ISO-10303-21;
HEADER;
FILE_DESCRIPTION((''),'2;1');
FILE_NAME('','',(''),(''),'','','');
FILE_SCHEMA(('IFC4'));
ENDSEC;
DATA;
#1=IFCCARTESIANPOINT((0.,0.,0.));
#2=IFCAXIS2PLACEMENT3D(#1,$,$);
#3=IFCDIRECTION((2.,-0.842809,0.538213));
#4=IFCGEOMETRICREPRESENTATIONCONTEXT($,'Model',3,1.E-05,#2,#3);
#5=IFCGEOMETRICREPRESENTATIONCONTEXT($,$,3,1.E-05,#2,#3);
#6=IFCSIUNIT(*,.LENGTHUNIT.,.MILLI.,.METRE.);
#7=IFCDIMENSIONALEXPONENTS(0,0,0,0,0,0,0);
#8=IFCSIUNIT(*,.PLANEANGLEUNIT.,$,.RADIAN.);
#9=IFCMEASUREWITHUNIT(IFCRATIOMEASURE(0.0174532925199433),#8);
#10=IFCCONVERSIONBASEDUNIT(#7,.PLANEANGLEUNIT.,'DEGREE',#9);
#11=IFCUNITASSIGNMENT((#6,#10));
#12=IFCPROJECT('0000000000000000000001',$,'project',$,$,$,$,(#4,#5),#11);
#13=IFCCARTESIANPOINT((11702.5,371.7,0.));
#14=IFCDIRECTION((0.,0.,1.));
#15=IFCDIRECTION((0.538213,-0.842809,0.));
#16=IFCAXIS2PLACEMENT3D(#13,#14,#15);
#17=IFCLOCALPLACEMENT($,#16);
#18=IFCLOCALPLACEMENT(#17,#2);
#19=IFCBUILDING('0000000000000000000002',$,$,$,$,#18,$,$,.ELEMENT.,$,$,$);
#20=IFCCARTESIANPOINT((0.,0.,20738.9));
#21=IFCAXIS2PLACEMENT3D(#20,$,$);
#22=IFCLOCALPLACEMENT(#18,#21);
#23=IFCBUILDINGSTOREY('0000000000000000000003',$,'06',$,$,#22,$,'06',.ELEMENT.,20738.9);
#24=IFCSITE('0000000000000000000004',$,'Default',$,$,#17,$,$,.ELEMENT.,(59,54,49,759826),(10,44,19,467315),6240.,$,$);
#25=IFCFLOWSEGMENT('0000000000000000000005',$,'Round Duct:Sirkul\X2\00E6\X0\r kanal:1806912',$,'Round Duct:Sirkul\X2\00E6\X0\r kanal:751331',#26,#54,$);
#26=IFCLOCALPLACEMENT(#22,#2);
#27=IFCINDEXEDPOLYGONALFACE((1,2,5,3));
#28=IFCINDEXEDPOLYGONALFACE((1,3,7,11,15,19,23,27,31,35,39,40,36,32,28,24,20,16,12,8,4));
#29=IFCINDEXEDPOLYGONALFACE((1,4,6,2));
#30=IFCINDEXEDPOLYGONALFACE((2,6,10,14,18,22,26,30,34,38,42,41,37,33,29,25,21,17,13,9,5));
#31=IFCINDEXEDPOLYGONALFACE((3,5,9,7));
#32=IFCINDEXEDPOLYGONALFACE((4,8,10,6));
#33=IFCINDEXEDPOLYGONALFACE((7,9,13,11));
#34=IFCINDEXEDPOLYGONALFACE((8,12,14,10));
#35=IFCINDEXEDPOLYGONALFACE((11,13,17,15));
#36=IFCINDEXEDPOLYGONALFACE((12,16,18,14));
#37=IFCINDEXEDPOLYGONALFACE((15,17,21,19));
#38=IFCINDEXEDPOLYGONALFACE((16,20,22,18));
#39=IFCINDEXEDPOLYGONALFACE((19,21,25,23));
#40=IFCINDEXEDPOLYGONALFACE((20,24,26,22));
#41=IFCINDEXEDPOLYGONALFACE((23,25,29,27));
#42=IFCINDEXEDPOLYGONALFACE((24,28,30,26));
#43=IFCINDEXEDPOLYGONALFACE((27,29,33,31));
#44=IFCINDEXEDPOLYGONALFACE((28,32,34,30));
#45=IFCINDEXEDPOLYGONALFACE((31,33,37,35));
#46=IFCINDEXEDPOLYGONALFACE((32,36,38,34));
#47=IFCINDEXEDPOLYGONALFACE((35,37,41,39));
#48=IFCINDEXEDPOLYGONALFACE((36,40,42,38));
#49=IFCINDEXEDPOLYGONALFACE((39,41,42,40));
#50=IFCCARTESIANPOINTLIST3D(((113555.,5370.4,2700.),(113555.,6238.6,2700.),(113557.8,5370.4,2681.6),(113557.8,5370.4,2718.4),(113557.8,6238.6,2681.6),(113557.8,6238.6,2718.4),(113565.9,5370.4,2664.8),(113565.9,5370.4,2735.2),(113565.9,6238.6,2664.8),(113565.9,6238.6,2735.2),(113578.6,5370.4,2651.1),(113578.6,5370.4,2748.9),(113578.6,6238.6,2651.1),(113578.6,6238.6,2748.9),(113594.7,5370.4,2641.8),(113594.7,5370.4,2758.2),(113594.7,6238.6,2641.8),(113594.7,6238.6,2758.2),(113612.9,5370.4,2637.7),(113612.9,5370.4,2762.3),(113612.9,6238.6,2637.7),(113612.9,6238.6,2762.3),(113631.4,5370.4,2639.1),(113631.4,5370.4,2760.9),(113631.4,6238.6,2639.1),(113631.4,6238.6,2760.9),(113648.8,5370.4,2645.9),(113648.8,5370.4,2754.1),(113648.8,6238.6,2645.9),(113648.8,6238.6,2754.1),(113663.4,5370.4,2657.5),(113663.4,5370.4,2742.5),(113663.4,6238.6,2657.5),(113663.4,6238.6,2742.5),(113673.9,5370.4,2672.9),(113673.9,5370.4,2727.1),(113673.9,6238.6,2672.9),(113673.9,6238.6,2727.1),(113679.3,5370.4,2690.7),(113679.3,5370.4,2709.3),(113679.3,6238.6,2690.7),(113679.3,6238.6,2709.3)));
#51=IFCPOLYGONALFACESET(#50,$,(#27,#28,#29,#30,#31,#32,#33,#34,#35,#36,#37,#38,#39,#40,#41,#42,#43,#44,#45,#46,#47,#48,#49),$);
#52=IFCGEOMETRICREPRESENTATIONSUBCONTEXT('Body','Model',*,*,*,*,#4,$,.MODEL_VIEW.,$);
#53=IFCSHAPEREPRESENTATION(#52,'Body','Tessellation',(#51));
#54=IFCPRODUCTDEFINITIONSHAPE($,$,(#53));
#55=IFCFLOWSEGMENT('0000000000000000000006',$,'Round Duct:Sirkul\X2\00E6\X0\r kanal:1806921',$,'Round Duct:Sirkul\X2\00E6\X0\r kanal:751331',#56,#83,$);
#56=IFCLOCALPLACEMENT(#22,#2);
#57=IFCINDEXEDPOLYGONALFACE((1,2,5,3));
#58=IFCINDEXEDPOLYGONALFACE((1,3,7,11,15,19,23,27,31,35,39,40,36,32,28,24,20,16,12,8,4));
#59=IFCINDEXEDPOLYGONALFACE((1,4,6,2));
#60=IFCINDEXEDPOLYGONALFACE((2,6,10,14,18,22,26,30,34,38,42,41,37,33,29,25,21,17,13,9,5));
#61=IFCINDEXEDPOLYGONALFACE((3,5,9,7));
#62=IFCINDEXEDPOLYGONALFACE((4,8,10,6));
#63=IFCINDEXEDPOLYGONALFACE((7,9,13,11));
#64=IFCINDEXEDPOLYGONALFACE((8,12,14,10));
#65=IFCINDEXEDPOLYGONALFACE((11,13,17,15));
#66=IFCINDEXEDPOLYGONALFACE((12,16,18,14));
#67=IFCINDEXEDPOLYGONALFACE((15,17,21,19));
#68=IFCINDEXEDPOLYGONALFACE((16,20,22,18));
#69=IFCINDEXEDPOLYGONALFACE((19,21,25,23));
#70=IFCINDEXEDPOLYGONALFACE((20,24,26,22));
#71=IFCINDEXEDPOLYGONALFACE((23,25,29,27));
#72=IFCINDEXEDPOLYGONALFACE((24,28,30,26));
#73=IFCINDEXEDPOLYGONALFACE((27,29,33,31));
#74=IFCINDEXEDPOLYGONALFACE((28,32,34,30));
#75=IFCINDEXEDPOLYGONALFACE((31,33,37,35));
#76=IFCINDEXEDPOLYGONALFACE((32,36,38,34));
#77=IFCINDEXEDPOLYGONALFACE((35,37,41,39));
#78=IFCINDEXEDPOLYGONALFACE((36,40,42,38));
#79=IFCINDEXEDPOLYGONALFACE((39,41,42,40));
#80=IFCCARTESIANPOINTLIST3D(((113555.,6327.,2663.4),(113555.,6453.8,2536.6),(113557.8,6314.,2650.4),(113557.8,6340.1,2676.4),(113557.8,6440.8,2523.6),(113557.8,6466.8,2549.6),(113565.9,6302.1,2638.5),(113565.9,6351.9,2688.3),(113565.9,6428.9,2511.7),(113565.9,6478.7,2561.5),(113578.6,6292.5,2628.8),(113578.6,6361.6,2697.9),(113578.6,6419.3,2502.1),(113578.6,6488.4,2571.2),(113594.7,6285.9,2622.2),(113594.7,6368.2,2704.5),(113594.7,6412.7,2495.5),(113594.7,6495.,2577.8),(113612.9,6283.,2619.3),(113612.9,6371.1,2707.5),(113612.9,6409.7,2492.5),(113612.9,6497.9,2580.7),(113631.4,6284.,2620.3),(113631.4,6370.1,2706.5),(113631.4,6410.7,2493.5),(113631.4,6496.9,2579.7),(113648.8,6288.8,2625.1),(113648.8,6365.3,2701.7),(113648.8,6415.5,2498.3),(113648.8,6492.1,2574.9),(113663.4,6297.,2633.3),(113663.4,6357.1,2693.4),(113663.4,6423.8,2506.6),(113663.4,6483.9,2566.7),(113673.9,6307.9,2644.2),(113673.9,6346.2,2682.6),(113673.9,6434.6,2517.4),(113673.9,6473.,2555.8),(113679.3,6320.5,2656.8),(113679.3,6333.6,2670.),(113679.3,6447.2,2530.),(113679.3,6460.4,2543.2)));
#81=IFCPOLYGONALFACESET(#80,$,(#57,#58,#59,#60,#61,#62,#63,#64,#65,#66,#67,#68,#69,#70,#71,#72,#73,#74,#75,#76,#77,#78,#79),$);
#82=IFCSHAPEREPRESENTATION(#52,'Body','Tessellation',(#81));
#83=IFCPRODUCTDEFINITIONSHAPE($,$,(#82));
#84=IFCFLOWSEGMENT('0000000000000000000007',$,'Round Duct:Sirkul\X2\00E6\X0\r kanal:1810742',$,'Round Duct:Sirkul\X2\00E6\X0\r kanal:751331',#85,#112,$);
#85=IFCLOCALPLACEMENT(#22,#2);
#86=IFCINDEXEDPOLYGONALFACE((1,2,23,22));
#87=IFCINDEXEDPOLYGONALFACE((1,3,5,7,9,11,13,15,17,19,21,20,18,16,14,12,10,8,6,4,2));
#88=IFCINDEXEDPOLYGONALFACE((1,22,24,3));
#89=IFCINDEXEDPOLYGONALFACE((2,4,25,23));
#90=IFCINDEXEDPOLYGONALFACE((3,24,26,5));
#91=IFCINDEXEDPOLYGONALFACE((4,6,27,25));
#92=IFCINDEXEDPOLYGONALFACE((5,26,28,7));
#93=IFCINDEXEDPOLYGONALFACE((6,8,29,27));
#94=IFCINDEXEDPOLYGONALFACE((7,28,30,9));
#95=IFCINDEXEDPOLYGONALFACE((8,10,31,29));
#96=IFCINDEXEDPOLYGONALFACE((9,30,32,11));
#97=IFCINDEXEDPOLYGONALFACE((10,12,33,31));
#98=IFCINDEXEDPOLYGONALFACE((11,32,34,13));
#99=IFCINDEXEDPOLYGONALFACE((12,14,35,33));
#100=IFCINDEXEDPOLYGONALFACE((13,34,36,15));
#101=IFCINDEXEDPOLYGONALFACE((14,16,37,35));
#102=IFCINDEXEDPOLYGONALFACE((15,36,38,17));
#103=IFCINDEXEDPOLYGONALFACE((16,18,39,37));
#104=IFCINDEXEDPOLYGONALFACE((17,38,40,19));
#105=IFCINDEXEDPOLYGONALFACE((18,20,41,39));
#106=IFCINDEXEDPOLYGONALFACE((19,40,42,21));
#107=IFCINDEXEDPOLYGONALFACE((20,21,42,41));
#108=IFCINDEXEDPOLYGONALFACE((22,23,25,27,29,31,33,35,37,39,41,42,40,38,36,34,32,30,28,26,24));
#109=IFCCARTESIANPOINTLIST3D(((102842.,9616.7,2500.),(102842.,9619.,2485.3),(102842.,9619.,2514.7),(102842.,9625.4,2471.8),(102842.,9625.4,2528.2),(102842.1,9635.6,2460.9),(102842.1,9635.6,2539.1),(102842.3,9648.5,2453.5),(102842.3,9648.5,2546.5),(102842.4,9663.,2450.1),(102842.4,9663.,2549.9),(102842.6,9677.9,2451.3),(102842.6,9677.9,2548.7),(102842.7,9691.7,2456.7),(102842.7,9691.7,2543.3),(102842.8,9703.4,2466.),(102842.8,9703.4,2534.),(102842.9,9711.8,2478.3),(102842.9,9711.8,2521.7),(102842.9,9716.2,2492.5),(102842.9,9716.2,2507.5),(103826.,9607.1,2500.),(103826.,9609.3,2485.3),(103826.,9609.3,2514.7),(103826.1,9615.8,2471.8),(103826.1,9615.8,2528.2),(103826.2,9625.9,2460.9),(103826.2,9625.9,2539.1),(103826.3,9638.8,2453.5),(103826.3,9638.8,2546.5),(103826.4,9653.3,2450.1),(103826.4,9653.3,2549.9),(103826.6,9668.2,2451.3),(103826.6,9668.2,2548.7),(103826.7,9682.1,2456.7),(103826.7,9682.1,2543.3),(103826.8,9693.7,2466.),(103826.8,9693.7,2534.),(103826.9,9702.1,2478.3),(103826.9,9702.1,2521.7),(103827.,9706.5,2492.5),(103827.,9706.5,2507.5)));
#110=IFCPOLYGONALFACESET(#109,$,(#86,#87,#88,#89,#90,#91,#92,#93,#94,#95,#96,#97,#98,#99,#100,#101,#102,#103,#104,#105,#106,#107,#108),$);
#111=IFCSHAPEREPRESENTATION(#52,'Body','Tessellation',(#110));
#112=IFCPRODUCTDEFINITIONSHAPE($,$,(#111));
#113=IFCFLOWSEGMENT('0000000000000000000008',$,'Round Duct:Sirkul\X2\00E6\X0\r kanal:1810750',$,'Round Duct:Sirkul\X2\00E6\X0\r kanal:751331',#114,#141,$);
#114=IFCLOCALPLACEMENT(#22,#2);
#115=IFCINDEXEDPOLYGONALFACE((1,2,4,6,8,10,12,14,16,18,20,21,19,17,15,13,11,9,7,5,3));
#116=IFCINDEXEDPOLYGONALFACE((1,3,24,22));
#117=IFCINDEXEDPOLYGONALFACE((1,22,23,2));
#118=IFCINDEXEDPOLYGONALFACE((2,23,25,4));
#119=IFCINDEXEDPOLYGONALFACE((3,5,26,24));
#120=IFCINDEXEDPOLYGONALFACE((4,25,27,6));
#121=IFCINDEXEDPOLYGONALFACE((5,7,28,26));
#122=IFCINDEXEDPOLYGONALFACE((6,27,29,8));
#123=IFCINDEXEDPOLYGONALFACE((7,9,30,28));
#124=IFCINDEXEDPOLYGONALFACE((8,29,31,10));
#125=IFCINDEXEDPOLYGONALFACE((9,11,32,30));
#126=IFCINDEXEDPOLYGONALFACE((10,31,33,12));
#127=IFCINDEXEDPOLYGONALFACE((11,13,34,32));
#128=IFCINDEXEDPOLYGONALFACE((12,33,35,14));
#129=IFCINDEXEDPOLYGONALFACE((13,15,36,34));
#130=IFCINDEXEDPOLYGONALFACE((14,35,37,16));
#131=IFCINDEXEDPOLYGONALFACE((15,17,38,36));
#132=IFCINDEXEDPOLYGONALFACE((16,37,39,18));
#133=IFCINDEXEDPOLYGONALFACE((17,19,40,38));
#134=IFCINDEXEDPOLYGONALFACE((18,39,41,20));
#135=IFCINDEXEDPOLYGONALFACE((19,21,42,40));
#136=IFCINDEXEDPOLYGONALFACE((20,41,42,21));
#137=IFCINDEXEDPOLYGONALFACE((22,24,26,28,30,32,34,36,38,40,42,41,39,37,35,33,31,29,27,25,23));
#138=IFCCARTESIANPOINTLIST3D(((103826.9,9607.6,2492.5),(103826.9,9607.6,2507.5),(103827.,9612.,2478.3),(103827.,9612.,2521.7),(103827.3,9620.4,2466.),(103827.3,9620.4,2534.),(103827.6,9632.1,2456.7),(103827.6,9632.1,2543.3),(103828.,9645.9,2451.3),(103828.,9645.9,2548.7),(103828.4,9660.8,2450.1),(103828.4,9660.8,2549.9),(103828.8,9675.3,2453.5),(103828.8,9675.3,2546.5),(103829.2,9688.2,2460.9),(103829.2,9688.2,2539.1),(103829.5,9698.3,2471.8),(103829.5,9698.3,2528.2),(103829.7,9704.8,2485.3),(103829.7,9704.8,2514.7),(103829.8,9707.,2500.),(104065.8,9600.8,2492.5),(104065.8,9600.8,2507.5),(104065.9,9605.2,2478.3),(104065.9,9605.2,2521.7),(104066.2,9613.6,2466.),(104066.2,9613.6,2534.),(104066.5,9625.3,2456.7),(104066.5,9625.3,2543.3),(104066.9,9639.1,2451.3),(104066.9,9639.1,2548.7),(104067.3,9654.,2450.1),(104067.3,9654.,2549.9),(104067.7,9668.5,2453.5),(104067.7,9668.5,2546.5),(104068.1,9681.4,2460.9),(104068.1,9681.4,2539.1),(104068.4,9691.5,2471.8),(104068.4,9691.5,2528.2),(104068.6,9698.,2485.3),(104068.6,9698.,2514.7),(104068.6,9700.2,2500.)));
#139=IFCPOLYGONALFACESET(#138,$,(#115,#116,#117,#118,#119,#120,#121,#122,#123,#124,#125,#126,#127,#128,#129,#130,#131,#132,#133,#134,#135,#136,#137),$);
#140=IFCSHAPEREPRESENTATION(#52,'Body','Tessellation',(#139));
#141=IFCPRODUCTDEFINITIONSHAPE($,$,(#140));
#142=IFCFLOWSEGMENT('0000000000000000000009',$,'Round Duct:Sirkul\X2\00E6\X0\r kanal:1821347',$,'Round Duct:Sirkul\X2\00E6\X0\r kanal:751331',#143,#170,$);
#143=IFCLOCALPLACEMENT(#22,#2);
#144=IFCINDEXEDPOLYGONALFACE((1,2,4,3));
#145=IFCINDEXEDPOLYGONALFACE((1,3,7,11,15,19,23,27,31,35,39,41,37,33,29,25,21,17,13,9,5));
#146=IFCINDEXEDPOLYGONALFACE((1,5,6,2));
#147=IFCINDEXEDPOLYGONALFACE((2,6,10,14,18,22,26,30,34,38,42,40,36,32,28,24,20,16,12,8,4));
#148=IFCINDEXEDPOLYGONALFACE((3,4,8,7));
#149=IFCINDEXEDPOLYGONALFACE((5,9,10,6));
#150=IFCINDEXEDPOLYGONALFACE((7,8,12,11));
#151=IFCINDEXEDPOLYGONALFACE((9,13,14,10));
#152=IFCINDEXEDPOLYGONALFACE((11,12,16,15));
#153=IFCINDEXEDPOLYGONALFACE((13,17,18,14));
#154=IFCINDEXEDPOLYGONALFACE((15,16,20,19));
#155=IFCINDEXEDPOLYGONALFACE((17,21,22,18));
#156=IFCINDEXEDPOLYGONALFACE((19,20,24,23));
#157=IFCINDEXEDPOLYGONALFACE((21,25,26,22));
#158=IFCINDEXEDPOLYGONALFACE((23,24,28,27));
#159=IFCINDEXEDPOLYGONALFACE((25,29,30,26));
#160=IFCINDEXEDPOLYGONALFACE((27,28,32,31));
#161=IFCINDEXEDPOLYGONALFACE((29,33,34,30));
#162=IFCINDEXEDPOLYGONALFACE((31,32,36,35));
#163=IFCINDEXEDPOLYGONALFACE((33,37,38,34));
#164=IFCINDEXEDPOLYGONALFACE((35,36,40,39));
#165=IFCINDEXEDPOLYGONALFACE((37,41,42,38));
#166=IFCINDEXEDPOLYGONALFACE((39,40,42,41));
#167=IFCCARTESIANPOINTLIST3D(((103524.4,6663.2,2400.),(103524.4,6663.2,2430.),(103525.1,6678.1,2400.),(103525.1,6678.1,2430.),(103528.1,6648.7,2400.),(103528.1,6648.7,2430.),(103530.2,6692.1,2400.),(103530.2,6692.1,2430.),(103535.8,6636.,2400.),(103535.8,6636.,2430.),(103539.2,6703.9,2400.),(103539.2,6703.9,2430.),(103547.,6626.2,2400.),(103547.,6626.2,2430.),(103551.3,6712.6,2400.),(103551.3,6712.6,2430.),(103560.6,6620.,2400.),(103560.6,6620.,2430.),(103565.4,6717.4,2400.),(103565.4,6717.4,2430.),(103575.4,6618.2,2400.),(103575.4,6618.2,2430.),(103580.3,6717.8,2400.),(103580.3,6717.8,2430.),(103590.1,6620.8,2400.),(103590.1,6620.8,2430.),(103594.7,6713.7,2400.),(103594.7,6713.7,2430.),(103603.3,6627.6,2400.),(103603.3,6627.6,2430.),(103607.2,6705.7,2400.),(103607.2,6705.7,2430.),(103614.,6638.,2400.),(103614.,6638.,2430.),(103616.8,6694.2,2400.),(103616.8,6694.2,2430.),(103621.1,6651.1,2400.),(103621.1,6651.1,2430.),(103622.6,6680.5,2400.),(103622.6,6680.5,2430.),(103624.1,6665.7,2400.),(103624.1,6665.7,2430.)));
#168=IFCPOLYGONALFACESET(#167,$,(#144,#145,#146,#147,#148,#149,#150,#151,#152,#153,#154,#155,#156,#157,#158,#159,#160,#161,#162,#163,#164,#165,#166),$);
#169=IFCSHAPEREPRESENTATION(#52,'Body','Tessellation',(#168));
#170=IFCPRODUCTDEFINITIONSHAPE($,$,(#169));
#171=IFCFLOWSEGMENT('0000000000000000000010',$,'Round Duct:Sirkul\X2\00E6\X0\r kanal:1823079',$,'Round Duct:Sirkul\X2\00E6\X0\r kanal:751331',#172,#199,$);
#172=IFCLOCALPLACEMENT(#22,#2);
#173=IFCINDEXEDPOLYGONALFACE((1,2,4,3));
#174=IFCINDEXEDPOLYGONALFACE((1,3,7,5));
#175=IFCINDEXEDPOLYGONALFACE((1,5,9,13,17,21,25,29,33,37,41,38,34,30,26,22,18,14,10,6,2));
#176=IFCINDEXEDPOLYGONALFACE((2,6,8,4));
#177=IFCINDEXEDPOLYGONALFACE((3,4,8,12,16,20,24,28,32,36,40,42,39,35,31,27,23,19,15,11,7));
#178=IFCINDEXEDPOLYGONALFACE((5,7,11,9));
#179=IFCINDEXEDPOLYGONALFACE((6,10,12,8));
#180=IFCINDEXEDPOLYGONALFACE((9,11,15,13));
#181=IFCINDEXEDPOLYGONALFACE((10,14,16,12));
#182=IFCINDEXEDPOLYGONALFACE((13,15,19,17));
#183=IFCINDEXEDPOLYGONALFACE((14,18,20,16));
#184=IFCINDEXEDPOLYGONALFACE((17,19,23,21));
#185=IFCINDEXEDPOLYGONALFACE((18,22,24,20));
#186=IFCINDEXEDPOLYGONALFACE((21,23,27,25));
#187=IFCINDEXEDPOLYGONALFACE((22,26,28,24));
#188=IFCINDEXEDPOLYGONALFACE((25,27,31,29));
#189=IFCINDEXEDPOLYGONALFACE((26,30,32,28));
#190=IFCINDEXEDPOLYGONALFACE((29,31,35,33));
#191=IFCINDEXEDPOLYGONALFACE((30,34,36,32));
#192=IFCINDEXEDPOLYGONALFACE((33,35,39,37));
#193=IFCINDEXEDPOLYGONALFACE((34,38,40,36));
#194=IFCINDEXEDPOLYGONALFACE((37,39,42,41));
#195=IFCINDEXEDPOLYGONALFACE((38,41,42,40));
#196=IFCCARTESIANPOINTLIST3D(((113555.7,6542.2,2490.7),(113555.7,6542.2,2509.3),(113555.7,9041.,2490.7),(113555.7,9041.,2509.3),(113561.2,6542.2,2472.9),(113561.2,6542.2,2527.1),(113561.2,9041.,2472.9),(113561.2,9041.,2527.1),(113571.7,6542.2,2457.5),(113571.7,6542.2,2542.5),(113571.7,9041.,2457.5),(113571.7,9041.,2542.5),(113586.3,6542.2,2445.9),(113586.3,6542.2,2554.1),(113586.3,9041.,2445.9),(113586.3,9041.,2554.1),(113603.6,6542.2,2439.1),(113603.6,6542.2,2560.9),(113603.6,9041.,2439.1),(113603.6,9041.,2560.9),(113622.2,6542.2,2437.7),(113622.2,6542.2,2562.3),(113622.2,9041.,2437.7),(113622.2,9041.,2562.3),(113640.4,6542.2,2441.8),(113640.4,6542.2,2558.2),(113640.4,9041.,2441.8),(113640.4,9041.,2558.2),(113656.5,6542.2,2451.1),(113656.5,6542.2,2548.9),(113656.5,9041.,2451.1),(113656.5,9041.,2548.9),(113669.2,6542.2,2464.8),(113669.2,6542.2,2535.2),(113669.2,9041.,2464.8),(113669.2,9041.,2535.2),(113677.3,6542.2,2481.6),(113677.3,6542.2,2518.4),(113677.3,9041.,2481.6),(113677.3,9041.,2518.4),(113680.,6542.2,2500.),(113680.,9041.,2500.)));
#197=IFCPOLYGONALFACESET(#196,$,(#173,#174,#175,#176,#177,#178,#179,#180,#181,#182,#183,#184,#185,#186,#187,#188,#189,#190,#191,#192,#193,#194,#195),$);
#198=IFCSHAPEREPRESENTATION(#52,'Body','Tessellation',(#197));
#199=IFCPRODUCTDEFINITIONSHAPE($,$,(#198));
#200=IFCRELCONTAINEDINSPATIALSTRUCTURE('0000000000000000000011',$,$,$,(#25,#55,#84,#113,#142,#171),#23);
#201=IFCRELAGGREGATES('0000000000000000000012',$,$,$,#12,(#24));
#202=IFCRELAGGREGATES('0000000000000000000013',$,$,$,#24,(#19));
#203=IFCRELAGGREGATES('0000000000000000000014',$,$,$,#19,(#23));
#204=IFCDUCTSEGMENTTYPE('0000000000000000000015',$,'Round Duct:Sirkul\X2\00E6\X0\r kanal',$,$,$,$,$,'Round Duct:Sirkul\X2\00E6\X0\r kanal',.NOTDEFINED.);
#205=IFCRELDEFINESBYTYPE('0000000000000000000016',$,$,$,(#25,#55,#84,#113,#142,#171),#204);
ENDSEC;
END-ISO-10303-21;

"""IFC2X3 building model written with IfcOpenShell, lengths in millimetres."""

from ifc_helpers import new_model, entity, si_unit, converted_unit, direction, frame, frame_2d, origin, origin_2d_with_axis, place, context, subcontext, project, spatial, circle, extrude, type_object, element, save


model = new_model("IFC2X3")

# Units and contexts
model_context = context("Model", 3, precision=1e-05, world=origin(), true_north=direction((2.0, -0.842809, 0.538213)))
context_of_model = context(None, 3, precision=1e-05, world=origin(), true_north=direction((2.0, -0.842809, 0.538213)))
body_context = subcontext(model_context, "Body", "Model", "MODEL_VIEW")
ifc_project = project(units=[si_unit("LENGTHUNIT", "METRE", prefix="MILLI"), converted_unit("PLANEANGLEUNIT", "DEGREE", entity("IfcRatioMeasure", 0.0174532925199433), si_unit("PLANEANGLEUNIT", "RADIAN"), dimensions=[0, 0, 0, 0, 0, 0, 0])], contexts=[model_context, context_of_model])

# Site, building, storey
site_placement = place(None, frame((11702.5, 371.7, 0.0), z_axis=(0.0, 0.0, 1.0), x_axis=(0.538213, -0.842809, 0.0)))
site = spatial("IfcSite", under=ifc_project, at=site_placement, Name="Default", CompositionType="ELEMENT", RefLatitude=(59, 54, 49, 759826), RefLongitude=(10, 44, 19, 467315), RefElevation=6240.0)
building_placement = place(site_placement, origin())
building = spatial("IfcBuilding", under=site, at=building_placement, CompositionType="ELEMENT")
storey_placement = place(building_placement, frame((0.0, 0.0, 20738.9)))
storey = spatial("IfcBuildingStorey", under=building, at=storey_placement, Name="06", LongName="06", CompositionType="ELEMENT", Elevation=20738.9)

# Flow segments
duct_segment_type = type_object("IfcDuctSegmentType", Name="Round Duct:Sirkulær kanal", ElementType="Round Duct:Sirkulær kanal", PredefinedType="NOTDEFINED")
flow_segment_1_placement = place(storey_placement, origin())
element("IfcFlowSegment", 1, at=flow_segment_1_placement, inside=storey, type_object=duct_segment_type, Name="Round Duct:Sirkulær kanal:1806912", ObjectType="Round Duct:Sirkulær kanal:751331", context=body_context, shape_type="SweptSolid", body=[
    extrude(circle(Radius=62.5, at=origin_2d_with_axis()), frame((113617.5, 5370.4, 2700.0), z_axis=(0.0, 1.0, 0.0), x_axis=(-1.0, 0.0, 0.0)), (0.0, 0.0, 1.0), 868.2),
])
flow_segment_2_placement = place(storey_placement, origin())
element("IfcFlowSegment", 2, at=flow_segment_2_placement, inside=storey, type_object=duct_segment_type, Name="Round Duct:Sirkulær kanal:1806921", ObjectType="Round Duct:Sirkulær kanal:751331", context=body_context, shape_type="SweptSolid", body=[
    extrude(circle(Radius=62.5, at=origin_2d_with_axis()), frame((113617.5, 6327.0, 2663.4), z_axis=(0.0, 0.707107, -0.707107), x_axis=(-1.0, 0.0, 0.0)), (0.0, 0.0, 1.0), 179.3),
])
flow_segment_3_placement = place(storey_placement, origin())
element("IfcFlowSegment", 3, at=flow_segment_3_placement, inside=storey, type_object=duct_segment_type, Name="Round Duct:Sirkulær kanal:1810742", ObjectType="Round Duct:Sirkulær kanal:751331", context=body_context, shape_type="SweptSolid", body=[
    extrude(circle(Radius=50.0, at=origin_2d_with_axis()), frame((102842.4, 9666.7, 2500.0), z_axis=(0.999952, -0.00981, 0.0), x_axis=(-0.00981, -0.999952, 0.0)), (0.0, 0.0, 1.0), 984.1),
])
flow_segment_4_placement = place(storey_placement, origin())
element("IfcFlowSegment", 4, at=flow_segment_4_placement, inside=storey, type_object=duct_segment_type, Name="Round Duct:Sirkulær kanal:1810750", ObjectType="Round Duct:Sirkulær kanal:751331", context=body_context, shape_type="SweptSolid", body=[
    extrude(circle(Radius=50.0, at=origin_2d_with_axis()), frame((104067.2, 9650.2, 2500.0), z_axis=(-0.999596, 0.028428, 0.0), x_axis=(0.028428, 0.999596, 0.0)), (0.0, 0.0, 1.0), 239.0),
])
flow_segment_5_placement = place(storey_placement, origin())
element("IfcFlowSegment", 5, at=flow_segment_5_placement, inside=storey, type_object=duct_segment_type, Name="Round Duct:Sirkulær kanal:1821347", ObjectType="Round Duct:Sirkulær kanal:751331", context=body_context, shape_type="SweptSolid", body=[
    extrude(circle(Radius=50.0, at=frame_2d((0.0, 0.0), x_axis=(1.0, 0.0))), frame((103574.1, 6668.2, 2400.0), z_axis=(0.0, 0.0, 1.0), x_axis=(0.025094, -0.999685, 0.0)), (0.0, 0.0, 1.0), 30.0),
])
flow_segment_6_placement = place(storey_placement, origin())
element("IfcFlowSegment", 6, at=flow_segment_6_placement, inside=storey, type_object=duct_segment_type, Name="Round Duct:Sirkulær kanal:1823079", ObjectType="Round Duct:Sirkulær kanal:751331", context=body_context, shape_type="SweptSolid", body=[
    extrude(circle(Radius=62.5, at=origin_2d_with_axis()), frame((113617.5, 6542.2, 2500.0), z_axis=(0.0, 1.0, 0.0), x_axis=(1.0, 0.0, 0.0)), (0.0, 0.0, 1.0), 2498.8),
])

save(model, "model.ifc")
